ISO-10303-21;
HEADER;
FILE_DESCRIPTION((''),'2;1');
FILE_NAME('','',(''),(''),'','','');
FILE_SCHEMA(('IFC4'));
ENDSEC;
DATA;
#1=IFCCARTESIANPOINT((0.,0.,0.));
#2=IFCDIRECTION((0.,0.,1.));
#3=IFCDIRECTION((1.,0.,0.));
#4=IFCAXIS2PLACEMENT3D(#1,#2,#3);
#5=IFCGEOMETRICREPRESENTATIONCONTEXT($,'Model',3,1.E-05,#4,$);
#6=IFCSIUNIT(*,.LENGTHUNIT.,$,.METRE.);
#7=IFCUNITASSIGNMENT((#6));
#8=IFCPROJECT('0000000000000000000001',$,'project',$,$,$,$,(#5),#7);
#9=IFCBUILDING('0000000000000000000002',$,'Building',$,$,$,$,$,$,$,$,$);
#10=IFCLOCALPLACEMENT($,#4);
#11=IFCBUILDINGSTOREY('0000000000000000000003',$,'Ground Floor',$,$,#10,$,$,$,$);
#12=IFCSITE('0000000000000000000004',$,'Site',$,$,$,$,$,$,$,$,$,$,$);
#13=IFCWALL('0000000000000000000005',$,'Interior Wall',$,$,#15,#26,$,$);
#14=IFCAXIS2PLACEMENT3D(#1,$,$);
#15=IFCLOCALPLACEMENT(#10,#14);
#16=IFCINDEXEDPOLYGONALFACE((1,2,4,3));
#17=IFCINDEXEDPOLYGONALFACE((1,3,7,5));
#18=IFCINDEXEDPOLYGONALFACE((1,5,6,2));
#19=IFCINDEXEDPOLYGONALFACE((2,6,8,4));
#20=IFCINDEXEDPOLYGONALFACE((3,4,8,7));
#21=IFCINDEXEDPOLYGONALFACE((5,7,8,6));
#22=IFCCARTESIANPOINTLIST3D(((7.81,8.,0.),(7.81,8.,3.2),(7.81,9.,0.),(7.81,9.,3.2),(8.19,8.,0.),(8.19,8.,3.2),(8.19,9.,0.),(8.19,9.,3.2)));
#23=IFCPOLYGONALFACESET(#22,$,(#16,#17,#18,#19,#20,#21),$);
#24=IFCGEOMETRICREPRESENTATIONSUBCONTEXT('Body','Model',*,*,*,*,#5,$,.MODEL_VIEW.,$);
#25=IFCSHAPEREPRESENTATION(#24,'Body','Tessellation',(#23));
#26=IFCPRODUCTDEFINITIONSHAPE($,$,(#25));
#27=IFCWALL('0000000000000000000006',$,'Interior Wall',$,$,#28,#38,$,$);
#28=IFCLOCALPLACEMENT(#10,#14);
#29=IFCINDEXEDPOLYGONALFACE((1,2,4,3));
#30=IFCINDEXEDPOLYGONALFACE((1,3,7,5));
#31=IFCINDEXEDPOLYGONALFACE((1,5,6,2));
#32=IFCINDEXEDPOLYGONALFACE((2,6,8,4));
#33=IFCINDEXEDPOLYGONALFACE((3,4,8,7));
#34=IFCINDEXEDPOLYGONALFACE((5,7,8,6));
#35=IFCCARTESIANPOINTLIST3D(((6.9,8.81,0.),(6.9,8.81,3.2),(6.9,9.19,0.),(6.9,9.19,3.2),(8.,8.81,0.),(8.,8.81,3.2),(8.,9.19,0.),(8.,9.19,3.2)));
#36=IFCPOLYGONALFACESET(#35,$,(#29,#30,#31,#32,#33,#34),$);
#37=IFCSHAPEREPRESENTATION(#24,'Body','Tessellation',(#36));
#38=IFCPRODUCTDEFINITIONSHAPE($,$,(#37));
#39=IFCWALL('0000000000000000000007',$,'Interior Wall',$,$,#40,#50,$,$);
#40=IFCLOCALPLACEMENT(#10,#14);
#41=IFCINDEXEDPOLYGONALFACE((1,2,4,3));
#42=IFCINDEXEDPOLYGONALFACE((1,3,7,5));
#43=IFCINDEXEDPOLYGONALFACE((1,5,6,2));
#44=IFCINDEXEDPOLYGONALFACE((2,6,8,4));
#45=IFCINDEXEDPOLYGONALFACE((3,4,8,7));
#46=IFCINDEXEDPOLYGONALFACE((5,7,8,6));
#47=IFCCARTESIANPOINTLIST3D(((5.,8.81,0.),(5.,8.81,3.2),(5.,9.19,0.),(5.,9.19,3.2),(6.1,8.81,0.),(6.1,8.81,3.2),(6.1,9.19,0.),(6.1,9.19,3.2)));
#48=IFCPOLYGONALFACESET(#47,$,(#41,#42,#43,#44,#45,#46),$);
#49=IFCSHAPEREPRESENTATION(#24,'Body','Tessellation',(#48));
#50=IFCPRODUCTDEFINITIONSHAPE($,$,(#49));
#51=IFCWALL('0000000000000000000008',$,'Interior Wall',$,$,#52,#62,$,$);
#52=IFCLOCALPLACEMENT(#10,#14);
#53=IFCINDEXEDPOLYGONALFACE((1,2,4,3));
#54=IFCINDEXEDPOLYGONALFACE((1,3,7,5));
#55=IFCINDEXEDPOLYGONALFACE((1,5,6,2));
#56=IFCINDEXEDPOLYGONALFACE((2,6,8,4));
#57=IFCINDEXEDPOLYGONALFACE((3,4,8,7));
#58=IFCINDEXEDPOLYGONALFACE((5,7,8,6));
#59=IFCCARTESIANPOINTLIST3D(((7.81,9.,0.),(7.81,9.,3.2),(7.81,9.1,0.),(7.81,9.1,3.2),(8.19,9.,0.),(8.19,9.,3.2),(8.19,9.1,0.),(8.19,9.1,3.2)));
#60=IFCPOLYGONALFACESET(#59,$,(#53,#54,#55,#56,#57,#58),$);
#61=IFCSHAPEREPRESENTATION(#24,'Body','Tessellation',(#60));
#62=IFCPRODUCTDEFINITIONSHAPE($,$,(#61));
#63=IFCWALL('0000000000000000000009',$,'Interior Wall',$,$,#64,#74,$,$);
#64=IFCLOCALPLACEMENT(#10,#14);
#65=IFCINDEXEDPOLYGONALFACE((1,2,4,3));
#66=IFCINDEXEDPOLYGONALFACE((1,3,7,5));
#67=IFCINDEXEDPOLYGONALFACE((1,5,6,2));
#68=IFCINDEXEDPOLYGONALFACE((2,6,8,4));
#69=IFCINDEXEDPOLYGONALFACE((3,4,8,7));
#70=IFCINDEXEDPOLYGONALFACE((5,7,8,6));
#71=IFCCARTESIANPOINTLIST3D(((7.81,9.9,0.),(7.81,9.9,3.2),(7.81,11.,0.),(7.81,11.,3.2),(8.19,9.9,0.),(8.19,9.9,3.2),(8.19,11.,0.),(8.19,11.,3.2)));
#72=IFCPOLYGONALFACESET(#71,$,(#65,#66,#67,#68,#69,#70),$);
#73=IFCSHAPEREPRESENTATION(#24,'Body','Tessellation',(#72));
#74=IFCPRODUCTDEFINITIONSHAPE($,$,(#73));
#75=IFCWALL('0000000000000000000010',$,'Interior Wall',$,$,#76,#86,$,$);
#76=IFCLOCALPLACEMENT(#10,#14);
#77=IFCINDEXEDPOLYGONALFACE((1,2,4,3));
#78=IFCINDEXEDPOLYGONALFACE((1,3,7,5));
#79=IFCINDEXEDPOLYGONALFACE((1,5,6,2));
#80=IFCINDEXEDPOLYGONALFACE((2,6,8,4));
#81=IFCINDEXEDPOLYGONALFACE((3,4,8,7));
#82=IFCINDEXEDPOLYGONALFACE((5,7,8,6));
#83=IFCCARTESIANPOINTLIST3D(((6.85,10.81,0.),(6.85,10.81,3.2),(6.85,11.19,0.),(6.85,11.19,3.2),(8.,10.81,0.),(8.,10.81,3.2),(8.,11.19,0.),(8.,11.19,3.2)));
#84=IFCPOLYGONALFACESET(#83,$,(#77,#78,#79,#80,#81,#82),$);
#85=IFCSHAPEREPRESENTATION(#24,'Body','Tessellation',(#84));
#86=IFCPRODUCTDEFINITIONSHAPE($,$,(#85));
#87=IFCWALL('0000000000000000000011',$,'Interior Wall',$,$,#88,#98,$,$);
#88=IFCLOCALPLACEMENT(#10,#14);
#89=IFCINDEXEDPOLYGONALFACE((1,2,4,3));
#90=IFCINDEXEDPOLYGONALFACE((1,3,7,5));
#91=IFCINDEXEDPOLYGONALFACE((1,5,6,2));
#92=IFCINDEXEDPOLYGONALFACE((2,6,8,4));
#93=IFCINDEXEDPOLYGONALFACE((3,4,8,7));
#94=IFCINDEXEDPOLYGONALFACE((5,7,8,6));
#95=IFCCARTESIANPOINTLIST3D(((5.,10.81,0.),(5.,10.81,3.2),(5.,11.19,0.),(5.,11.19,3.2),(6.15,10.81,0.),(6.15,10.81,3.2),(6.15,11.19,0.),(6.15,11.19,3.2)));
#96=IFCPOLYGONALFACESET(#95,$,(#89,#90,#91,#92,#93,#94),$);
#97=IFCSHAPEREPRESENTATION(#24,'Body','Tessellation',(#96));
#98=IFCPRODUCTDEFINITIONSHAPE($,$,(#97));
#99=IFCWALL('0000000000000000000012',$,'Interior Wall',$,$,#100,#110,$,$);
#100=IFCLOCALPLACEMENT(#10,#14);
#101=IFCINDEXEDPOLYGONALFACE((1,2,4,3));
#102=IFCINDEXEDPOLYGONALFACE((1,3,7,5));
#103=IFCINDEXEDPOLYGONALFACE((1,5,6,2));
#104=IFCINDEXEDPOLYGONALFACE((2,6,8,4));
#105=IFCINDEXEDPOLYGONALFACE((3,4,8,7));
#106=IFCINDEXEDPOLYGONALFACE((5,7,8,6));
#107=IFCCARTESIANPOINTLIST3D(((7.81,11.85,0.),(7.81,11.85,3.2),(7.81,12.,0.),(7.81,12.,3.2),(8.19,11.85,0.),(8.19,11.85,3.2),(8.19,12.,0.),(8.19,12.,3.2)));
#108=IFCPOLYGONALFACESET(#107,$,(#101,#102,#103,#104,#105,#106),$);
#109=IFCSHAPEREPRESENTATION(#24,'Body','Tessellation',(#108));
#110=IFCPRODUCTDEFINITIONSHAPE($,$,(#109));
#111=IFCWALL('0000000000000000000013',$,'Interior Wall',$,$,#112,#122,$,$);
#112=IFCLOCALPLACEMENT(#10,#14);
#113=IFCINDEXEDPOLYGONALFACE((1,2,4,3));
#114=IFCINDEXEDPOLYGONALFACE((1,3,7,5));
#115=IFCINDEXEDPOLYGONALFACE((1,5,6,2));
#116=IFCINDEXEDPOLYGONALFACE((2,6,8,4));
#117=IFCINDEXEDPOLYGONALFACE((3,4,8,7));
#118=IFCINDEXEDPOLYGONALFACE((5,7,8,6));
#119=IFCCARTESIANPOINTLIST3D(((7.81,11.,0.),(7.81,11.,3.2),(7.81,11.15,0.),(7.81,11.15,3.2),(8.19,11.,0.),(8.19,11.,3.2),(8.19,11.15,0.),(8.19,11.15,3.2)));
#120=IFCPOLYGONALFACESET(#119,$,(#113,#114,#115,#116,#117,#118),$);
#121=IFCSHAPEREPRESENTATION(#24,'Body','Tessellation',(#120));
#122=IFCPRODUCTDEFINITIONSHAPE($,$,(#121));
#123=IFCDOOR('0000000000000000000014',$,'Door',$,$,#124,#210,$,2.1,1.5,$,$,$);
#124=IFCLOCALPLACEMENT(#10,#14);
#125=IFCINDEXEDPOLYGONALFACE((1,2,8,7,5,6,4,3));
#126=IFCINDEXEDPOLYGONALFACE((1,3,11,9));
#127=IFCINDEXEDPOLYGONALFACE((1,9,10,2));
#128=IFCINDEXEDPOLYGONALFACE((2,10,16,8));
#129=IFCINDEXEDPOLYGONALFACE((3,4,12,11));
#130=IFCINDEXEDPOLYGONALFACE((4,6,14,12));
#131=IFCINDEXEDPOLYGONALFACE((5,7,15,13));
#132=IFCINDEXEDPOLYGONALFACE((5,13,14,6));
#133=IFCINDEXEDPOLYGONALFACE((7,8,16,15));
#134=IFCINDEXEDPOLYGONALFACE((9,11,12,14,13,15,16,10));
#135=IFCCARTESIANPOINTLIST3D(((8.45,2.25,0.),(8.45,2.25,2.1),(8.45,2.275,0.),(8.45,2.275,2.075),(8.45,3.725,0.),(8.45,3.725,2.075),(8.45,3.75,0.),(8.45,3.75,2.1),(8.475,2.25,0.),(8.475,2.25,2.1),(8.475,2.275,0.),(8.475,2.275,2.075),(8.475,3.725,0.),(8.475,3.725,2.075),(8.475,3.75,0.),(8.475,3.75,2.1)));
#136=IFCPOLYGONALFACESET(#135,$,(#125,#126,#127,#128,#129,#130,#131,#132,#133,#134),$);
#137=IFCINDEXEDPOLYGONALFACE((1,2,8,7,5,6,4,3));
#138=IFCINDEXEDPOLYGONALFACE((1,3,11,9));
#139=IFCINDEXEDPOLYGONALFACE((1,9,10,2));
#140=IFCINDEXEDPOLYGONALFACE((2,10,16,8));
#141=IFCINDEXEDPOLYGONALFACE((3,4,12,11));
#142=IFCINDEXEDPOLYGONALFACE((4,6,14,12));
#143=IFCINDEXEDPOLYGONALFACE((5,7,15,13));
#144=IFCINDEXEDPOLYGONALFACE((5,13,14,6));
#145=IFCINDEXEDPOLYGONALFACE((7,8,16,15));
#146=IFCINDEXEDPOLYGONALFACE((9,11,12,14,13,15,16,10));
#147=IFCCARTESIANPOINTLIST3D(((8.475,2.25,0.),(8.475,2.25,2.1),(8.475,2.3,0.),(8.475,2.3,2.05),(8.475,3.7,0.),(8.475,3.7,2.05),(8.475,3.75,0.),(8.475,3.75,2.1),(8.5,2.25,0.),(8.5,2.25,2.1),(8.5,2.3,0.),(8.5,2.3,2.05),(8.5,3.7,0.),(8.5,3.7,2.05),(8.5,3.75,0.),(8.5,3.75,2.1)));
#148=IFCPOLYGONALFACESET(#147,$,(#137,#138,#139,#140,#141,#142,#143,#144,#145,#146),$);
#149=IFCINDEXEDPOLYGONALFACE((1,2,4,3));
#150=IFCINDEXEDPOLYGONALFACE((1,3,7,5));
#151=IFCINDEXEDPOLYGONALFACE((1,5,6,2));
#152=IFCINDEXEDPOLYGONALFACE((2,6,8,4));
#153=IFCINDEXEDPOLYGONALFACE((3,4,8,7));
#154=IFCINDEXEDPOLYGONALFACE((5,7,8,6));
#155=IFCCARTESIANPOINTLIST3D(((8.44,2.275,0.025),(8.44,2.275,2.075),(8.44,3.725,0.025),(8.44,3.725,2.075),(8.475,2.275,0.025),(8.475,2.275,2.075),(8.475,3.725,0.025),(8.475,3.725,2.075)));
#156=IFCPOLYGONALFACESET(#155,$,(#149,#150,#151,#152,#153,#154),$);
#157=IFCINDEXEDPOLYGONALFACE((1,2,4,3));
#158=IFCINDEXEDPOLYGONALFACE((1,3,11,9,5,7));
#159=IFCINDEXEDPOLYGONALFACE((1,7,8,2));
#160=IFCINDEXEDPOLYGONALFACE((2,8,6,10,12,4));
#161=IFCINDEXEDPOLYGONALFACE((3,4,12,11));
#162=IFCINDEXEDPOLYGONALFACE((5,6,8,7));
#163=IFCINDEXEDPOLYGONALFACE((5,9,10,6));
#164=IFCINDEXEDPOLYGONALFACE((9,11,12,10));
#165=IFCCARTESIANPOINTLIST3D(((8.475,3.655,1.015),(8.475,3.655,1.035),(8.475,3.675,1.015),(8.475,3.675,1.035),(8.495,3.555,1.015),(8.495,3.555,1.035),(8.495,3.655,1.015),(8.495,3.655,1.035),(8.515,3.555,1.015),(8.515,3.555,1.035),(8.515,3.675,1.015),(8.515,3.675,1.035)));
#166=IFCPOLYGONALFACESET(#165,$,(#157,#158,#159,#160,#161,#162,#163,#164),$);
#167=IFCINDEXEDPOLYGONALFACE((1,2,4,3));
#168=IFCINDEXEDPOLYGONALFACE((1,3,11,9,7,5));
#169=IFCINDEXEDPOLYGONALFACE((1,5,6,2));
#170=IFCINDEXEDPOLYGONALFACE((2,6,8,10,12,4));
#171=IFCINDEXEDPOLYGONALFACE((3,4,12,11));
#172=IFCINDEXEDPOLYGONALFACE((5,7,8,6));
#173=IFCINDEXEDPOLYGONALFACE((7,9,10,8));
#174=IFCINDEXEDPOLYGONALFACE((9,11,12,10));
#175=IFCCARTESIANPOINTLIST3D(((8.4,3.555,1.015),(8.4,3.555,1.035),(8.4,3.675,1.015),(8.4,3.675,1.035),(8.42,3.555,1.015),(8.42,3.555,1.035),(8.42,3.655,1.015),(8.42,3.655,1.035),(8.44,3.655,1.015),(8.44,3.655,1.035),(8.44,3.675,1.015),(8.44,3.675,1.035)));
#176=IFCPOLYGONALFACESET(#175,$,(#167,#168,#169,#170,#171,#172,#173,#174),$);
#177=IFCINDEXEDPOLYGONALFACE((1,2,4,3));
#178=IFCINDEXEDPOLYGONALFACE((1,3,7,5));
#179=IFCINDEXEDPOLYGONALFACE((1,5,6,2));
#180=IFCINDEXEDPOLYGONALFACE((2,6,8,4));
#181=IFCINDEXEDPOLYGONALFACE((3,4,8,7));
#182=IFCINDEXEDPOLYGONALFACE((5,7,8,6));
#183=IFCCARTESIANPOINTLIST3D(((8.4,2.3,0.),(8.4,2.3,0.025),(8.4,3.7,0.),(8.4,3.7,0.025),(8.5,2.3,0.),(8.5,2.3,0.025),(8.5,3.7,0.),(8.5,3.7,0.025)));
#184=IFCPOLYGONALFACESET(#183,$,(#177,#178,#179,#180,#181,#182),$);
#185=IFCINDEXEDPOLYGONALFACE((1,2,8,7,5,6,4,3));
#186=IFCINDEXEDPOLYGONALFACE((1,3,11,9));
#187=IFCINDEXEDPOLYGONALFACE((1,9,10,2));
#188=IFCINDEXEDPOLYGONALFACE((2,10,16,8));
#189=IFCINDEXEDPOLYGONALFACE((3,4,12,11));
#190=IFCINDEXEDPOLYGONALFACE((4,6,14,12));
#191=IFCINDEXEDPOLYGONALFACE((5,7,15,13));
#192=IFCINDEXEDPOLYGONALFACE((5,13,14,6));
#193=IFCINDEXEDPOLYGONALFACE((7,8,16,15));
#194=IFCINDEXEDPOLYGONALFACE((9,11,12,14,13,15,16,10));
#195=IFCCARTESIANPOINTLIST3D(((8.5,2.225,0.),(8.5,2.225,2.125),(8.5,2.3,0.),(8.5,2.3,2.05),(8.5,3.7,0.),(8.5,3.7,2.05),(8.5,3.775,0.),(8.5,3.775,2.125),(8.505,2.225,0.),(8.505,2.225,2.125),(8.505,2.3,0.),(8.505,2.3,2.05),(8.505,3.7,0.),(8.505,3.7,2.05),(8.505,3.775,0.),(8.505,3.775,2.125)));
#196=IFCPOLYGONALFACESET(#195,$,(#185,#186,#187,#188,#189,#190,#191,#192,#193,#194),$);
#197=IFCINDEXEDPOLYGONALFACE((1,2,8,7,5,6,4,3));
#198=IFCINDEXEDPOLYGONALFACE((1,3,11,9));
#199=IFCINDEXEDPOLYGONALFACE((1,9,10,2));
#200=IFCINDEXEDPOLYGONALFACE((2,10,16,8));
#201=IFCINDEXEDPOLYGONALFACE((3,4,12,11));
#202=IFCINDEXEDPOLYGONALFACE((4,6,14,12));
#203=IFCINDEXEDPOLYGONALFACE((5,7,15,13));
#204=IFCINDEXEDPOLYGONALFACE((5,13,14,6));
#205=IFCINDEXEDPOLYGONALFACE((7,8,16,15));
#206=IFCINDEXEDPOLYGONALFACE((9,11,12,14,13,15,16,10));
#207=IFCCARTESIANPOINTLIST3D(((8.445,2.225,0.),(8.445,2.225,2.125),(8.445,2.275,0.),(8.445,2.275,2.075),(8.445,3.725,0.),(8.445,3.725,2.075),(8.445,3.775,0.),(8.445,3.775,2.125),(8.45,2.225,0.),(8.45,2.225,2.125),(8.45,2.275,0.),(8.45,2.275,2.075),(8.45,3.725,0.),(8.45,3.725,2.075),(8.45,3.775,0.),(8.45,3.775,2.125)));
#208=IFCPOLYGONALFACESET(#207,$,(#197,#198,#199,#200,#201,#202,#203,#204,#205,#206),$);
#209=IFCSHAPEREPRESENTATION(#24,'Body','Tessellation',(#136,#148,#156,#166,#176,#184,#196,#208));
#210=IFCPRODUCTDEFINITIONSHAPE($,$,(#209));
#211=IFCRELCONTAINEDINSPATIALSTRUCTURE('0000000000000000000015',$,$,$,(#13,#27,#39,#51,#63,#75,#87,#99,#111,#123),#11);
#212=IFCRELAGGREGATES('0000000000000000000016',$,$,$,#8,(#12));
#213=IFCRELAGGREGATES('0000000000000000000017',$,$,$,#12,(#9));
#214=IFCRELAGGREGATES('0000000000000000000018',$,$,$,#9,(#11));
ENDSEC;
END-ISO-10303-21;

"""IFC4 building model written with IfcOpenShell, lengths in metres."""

from ifc_helpers import new_model, si_unit, frame, origin_with_axes, place, context, subcontext, project, spatial, line, indexed_curve, outline, extrude, element, save


model = new_model("IFC4")

# Units and contexts
model_context = context("Model", 3, precision=1e-05, world=origin_with_axes())
body_context = subcontext(model_context, "Body", "Model", "MODEL_VIEW")
ifc_project = project(units=[si_unit("LENGTHUNIT", "METRE")], contexts=[model_context])

# Site, building, storey
site = spatial("IfcSite", under=ifc_project, Name="Site")
building = spatial("IfcBuilding", under=site, Name="Building")
storey_placement = place(None, origin_with_axes())
storey = spatial("IfcBuildingStorey", under=building, at=storey_placement, Name="Ground Floor")

# Walls
wall_1_placement = place(storey_placement, frame((8.0, 8.0, 0.0), z_axis=(0.0, 0.0, 1.0), x_axis=(0.0, 1.0, 0.0)))
element("IfcWall", 1, at=wall_1_placement, inside=storey, Name="Interior Wall", context=body_context, shape_type="SweptSolid", body=[
    extrude(outline(indexed_curve([(0.0, 0.0), (0.0, 0.38), (1.0, 0.38), (1.0, 0.0), (0.0, 0.0)], self_intersect=False)), frame((0.0, -0.19, 0.0), z_axis=(0.0, 0.0, 1.0), x_axis=(1.0, 0.0, 0.0)), (0.0, 0.0, 1.0), 3.2),
])
for number, where, z_axis, x_axis, name in (
    (2, (8.0, 9.0, 0.0), (0.0, 0.0, 1.0), (-1.0, 0.0, 0.0), "Interior Wall"),
    (3, (6.1, 9.0, 0.0), (0.0, 0.0, 1.0), (-1.0, 0.0, 0.0), "Interior Wall"),
):
    element("IfcWall", number, at=place(storey_placement, frame(where, z_axis=z_axis, x_axis=x_axis)), inside=storey, Name=name, context=body_context, shape_type="SweptSolid", body=[
        extrude(outline(indexed_curve([(0.0, 0.0), (0.0, 0.38), (1.1, 0.38), (1.1, 0.0), (0.0, 0.0)], self_intersect=False)), frame((0.0, -0.19, 0.0), z_axis=(0.0, 0.0, 1.0), x_axis=(1.0, 0.0, 0.0)), (0.0, 0.0, 1.0), 3.2),
    ])
wall_2_placement = place(storey_placement, frame((8.0, 9.0, 0.0), z_axis=(0.0, 0.0, 1.0), x_axis=(0.0, 1.0, 0.0)))
element("IfcWall", 4, at=wall_2_placement, inside=storey, Name="Interior Wall", context=body_context, shape_type="SweptSolid", body=[
    extrude(outline(indexed_curve([(0.0, 0.0), (0.0, 0.38), (0.1, 0.38), (0.1, 0.0), (0.0, 0.0)], self_intersect=False)), frame((0.0, -0.19, 0.0), z_axis=(0.0, 0.0, 1.0), x_axis=(1.0, 0.0, 0.0)), (0.0, 0.0, 1.0), 3.2),
])
wall_3_placement = place(storey_placement, frame((8.0, 9.9, 0.0), z_axis=(0.0, 0.0, 1.0), x_axis=(0.0, 1.0, 0.0)))
element("IfcWall", 5, at=wall_3_placement, inside=storey, Name="Interior Wall", context=body_context, shape_type="SweptSolid", body=[
    extrude(outline(indexed_curve([(0.0, 0.0), (0.0, 0.38), (1.1, 0.38), (1.1, 0.0), (0.0, 0.0)], self_intersect=False)), frame((0.0, -0.19, 0.0), z_axis=(0.0, 0.0, 1.0), x_axis=(1.0, 0.0, 0.0)), (0.0, 0.0, 1.0), 3.2),
])
for number, where, z_axis, x_axis, name in (
    (6, (8.0, 11.0, 0.0), (0.0, 0.0, 1.0), (-1.0, 0.0, 0.0), "Interior Wall"),
    (7, (6.15, 11.0, 0.0), (0.0, 0.0, 1.0), (-1.0, 0.0, 0.0), "Interior Wall"),
):
    element("IfcWall", number, at=place(storey_placement, frame(where, z_axis=z_axis, x_axis=x_axis)), inside=storey, Name=name, context=body_context, shape_type="SweptSolid", body=[
        extrude(outline(indexed_curve([(0.0, 0.0), (0.0, 0.38), (1.15, 0.38), (1.15, 0.0), (0.0, 0.0)], self_intersect=False)), frame((0.0, -0.19, 0.0), z_axis=(0.0, 0.0, 1.0), x_axis=(1.0, 0.0, 0.0)), (0.0, 0.0, 1.0), 3.2),
    ])
for number, where, z_axis, x_axis, name in (
    (8, (8.0, 12.0, 0.0), (0.0, 0.0, 1.0), (0.0, -1.0, 0.0), "Interior Wall"),
    (9, (8.0, 11.15, 0.0), (0.0, 0.0, 1.0), (0.0, -1.0, 0.0), "Interior Wall"),
):
    element("IfcWall", number, at=place(storey_placement, frame(where, z_axis=z_axis, x_axis=x_axis)), inside=storey, Name=name, context=body_context, shape_type="SweptSolid", body=[
        extrude(outline(indexed_curve([(0.0, 0.0), (0.0, 0.38), (0.15, 0.38), (0.15, 0.0), (0.0, 0.0)], self_intersect=False)), frame((0.0, -0.19, 0.0), z_axis=(0.0, 0.0, 1.0), x_axis=(1.0, 0.0, 0.0)), (0.0, 0.0, 1.0), 3.2),
    ])

# Door
door_1_placement = place(storey_placement, frame((8.5, 2.25, 0.0), z_axis=(0.0, 0.0, 1.0), x_axis=(0.0, 1.0, 0.0)))
element("IfcDoor", 10, at=door_1_placement, inside=storey, Name="Door", OverallHeight=2.1, OverallWidth=1.5, context=body_context, shape_type="SweptSolid", body=[
    extrude(outline(indexed_curve([(0.0, 0.0), (0.0, 2.1), (1.5, 2.1), (1.5, 0.0), (1.475, 0.0), (1.475, 2.075), (0.025, 2.075), (0.025, 0.0)], segments=[line(1, 2, 3, 4, 5, 6, 7, 8, 1)])), frame((0.0, 0.025, 0.0), z_axis=(0.0, -1.0, 0.0), x_axis=(1.0, 0.0, 0.0)), (0.0, 0.0, -1.0), 0.025),
    extrude(outline(indexed_curve([(0.0, 0.0), (0.0, 2.1), (1.5, 2.1), (1.5, 0.0), (1.45, 0.0), (1.45, 2.05), (0.05, 2.05), (0.05, 0.0)], segments=[line(1, 2, 3, 4, 5, 6, 7, 8, 1)])), frame((0.0, 0.0, 0.0), z_axis=(0.0, -1.0, 0.0), x_axis=(1.0, 0.0, 0.0)), (0.0, 0.0, -1.0), 0.025),
    extrude(outline(indexed_curve([(0.0, 0.0), (1.45, 0.0), (1.45, 0.035), (0.0, 0.035)], segments=[line(1, 2, 3, 4, 1)])), frame((0.025, 0.025, 0.025), z_axis=(0.0, 0.0, 1.0), x_axis=(1.0, 0.0, 0.0)), (0.0, 0.0, 1.0), 2.05),
    extrude(outline(indexed_curve([(0.0, 0.0), (0.0, -0.04), (-0.12, -0.04), (-0.12, -0.02), (-0.02, -0.02), (-0.02, 0.0)], segments=[line(1, 2, 3, 4, 5, 6, 1)])), frame((1.425, 0.025, 1.015), z_axis=(0.0, 0.0, 1.0), x_axis=(1.0, 0.0, 0.0)), (0.0, 0.0, 1.0), 0.02),
    extrude(outline(indexed_curve([(0.0, 0.0), (0.0, 0.04), (-0.12, 0.04), (-0.12, 0.02), (-0.02, 0.02), (-0.02, 0.0)], segments=[line(1, 2, 3, 4, 5, 6, 1)])), frame((1.425, 0.06, 1.015), z_axis=(0.0, 0.0, 1.0), x_axis=(1.0, 0.0, 0.0)), (0.0, 0.0, 1.0), 0.02),
    extrude(outline(indexed_curve([(0.0, 0.0), (1.4, 0.0), (1.4, 0.1), (0.0, 0.1)], segments=[line(1, 2, 3, 4, 1)])), frame((0.05, 0.0, 0.0), z_axis=(0.0, 0.0, 1.0), x_axis=(1.0, 0.0, 0.0)), (0.0, 0.0, 1.0), 0.025),
    extrude(outline(indexed_curve([(0.0, 0.0), (0.0, 2.125), (1.55, 2.125), (1.55, 0.0), (1.475, 0.0), (1.475, 2.05), (0.075, 2.05), (0.075, 0.0)], segments=[line(1, 2, 3, 4, 5, 6, 7, 8, 1)])), frame((-0.025, -0.005, 0.0), z_axis=(0.0, -1.0, 0.0), x_axis=(1.0, 0.0, 0.0)), (0.0, 0.0, -1.0), 0.005),
    extrude(outline(indexed_curve([(0.0, 0.0), (0.0, 2.125), (1.55, 2.125), (1.55, 0.0), (1.5, 0.0), (1.5, 2.075), (0.05, 2.075), (0.05, 0.0)], segments=[line(1, 2, 3, 4, 5, 6, 7, 8, 1)])), frame((-0.025, 0.05, 0.0), z_axis=(0.0, -1.0, 0.0), x_axis=(1.0, 0.0, 0.0)), (0.0, 0.0, -1.0), 0.005),
])

save(model, "model.ifc")
